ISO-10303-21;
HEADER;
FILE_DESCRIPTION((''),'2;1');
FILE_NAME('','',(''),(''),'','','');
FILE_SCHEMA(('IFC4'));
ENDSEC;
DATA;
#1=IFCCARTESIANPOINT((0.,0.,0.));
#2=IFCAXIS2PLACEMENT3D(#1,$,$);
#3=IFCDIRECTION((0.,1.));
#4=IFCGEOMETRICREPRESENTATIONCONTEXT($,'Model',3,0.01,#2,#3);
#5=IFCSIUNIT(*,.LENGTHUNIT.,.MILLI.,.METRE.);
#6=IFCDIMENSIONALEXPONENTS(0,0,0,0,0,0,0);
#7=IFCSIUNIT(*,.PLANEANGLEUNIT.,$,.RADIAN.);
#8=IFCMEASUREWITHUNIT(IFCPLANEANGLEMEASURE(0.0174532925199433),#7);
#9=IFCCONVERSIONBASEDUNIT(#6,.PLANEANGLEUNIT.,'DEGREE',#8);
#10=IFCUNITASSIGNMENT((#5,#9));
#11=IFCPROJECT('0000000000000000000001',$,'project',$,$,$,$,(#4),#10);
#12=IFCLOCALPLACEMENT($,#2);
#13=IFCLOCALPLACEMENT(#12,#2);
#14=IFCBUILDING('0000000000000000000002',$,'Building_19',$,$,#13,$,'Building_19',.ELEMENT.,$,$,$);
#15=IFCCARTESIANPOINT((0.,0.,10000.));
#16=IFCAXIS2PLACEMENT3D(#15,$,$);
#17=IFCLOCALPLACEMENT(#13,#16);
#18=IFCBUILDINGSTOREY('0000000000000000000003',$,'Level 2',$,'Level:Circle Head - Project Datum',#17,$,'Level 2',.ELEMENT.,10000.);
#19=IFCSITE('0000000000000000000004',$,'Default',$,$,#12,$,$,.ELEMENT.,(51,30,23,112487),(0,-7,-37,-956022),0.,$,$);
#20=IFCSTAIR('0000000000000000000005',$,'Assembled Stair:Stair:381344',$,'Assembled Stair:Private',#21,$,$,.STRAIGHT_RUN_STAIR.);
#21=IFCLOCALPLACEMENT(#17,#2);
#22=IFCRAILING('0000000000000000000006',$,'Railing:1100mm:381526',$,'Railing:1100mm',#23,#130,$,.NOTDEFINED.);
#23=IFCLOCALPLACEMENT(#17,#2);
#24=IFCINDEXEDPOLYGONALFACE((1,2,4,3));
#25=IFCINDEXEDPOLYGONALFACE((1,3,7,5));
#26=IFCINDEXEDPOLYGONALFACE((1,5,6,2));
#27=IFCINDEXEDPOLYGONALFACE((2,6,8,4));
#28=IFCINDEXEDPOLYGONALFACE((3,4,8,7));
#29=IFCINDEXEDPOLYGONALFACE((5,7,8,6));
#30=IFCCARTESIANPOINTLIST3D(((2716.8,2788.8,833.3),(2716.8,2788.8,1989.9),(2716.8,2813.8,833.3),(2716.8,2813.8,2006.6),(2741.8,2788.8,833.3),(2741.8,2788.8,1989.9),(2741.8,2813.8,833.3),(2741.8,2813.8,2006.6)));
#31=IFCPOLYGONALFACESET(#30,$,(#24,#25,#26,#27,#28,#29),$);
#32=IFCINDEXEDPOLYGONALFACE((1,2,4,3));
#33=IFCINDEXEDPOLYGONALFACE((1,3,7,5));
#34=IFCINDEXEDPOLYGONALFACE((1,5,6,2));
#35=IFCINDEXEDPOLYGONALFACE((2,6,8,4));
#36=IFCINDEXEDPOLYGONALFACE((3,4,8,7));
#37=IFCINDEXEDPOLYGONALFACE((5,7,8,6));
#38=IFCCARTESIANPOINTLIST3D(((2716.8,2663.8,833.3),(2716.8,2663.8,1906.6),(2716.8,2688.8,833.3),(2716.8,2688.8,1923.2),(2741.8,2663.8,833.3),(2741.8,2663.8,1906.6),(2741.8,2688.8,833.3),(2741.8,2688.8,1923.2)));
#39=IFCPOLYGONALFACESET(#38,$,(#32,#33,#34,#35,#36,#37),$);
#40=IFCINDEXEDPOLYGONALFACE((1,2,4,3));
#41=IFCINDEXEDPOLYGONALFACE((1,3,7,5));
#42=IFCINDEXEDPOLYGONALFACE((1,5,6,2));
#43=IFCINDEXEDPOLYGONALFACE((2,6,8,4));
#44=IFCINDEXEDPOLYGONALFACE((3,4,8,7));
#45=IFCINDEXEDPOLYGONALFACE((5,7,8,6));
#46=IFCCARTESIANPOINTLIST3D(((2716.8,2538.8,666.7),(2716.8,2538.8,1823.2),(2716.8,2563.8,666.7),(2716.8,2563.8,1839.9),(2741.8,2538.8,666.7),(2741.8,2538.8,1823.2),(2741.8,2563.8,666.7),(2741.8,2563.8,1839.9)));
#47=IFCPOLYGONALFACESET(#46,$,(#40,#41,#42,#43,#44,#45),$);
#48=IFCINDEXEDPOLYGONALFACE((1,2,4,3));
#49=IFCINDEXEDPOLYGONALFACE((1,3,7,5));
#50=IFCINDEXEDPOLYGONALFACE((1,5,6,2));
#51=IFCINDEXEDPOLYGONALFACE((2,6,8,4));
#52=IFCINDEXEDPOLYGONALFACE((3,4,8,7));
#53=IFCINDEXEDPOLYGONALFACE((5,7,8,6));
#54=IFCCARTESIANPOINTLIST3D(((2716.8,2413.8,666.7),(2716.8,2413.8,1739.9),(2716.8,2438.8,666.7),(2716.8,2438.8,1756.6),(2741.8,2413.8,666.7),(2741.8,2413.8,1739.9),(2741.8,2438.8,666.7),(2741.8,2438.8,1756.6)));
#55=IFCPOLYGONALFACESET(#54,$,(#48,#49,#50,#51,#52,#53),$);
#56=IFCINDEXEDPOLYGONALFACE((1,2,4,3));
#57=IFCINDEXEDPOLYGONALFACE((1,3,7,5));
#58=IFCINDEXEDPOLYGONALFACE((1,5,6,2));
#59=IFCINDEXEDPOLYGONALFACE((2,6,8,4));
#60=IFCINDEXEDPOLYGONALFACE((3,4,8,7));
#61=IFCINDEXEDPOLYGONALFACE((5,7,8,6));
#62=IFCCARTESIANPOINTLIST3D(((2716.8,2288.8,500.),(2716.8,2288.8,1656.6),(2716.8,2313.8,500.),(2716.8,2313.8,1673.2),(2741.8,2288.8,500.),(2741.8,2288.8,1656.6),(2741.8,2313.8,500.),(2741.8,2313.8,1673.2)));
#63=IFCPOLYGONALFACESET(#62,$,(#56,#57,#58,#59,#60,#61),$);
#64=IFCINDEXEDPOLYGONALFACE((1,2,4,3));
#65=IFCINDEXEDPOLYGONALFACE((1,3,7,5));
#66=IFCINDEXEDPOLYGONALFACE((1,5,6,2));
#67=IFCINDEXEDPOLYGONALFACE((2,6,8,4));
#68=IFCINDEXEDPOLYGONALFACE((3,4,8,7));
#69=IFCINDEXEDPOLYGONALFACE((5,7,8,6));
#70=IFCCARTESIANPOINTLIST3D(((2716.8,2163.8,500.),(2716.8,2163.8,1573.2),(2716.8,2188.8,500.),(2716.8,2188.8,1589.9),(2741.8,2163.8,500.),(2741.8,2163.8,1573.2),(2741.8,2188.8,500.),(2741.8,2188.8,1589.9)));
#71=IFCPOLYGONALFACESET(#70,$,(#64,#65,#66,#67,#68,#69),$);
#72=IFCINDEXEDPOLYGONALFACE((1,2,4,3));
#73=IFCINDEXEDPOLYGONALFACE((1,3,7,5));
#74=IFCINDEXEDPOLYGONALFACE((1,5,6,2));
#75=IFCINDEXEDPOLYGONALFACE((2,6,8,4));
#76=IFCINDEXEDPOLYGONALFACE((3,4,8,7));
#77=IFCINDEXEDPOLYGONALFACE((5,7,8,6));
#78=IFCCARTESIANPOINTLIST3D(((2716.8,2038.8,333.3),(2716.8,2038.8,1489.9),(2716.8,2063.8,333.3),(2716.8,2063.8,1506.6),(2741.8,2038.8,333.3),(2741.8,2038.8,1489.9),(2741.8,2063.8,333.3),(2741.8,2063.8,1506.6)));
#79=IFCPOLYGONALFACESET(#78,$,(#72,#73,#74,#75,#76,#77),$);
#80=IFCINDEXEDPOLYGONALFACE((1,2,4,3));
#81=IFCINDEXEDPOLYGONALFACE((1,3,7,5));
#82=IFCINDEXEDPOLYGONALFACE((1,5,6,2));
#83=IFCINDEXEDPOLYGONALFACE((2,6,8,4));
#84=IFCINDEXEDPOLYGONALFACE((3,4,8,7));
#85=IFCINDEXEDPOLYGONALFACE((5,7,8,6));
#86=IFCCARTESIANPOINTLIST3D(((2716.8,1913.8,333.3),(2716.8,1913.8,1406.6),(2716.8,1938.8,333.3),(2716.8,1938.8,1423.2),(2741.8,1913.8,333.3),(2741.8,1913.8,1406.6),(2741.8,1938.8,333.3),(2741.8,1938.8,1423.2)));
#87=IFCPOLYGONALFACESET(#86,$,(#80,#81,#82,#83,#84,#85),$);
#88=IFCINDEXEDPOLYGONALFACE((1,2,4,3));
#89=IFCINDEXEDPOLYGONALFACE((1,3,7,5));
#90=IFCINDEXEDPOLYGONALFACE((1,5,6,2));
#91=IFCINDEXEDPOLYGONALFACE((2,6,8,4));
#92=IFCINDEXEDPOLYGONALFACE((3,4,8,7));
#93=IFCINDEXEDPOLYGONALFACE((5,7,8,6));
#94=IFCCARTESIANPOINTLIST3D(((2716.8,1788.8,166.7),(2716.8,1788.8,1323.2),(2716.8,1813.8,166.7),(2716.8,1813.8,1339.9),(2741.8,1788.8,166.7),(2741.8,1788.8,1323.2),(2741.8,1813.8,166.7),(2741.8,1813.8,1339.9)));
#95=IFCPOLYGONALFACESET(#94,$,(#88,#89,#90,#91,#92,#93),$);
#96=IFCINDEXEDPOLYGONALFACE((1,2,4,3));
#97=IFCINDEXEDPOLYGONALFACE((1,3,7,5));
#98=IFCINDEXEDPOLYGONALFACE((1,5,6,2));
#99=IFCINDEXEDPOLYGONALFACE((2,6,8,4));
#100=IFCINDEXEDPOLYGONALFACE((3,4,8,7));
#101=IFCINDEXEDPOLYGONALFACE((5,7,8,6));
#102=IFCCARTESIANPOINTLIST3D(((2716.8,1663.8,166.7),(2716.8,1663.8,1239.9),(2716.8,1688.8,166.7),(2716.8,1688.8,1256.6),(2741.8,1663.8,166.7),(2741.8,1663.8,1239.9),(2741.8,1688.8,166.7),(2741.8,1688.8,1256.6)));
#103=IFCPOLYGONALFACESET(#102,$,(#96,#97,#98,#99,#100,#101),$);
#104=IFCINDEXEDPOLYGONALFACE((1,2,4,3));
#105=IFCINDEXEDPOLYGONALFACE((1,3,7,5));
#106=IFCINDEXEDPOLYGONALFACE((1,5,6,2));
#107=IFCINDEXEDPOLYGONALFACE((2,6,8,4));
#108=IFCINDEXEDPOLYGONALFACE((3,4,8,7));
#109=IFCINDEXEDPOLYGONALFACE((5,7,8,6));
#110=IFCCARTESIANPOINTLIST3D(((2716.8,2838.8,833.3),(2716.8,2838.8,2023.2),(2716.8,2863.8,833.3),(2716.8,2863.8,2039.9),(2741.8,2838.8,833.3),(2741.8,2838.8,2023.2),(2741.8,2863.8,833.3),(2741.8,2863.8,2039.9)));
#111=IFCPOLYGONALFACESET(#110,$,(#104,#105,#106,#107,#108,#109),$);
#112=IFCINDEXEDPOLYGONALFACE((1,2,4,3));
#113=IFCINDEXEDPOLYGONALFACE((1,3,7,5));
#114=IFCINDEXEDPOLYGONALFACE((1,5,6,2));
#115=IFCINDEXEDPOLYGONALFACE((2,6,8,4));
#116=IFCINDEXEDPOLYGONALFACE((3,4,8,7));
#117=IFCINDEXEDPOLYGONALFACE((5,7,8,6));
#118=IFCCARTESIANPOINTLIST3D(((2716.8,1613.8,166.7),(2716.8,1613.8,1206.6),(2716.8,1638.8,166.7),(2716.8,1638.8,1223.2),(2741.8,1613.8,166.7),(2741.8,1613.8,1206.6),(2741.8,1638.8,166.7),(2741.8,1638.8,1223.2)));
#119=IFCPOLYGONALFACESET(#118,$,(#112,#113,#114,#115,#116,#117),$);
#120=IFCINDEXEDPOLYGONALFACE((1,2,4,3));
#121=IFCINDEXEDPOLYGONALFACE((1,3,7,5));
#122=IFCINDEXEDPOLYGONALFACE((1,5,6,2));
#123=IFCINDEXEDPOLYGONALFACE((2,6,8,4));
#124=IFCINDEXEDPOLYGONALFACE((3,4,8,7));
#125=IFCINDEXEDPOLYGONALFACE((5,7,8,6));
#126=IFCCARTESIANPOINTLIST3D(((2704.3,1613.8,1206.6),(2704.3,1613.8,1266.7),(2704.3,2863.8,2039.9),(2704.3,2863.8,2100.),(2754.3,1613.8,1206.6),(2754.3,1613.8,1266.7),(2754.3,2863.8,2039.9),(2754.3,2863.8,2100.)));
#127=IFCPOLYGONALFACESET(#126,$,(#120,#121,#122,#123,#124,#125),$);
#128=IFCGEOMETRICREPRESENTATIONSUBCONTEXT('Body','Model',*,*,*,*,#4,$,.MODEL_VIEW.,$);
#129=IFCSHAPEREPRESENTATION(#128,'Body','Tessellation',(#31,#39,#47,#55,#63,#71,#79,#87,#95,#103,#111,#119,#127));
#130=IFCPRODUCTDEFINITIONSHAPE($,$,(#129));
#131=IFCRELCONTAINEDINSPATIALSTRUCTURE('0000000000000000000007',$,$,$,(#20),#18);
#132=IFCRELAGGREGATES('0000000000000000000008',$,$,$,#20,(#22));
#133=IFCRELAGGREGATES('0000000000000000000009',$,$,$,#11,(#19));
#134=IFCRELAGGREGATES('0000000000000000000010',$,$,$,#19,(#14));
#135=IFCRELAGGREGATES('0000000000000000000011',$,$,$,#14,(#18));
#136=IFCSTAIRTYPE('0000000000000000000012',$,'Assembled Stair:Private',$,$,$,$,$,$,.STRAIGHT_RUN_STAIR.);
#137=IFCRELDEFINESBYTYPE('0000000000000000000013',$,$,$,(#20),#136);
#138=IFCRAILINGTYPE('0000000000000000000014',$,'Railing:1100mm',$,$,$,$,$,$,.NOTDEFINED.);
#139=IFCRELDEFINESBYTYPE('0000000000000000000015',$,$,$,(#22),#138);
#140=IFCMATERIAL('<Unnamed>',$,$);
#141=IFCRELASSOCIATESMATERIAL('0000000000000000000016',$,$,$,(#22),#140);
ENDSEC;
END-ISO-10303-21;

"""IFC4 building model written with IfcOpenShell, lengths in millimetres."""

from ifc_helpers import new_model, entity, si_unit, converted_unit, direction, frame, origin, place, context, subcontext, project, spatial, indexed_curve, outline, extrude, material, type_object, element, aggregate, save


model = new_model("IFC4")

# Units and contexts
model_context = context("Model", 3, precision=0.01, world=origin(), true_north=direction((0.0, 1.0)))
body_context = subcontext(model_context, "Body", "Model", "MODEL_VIEW")
ifc_project = project(units=[si_unit("LENGTHUNIT", "METRE", prefix="MILLI"), converted_unit("PLANEANGLEUNIT", "DEGREE", entity("IfcPlaneAngleMeasure", 0.0174532925199433), si_unit("PLANEANGLEUNIT", "RADIAN"), dimensions=[0, 0, 0, 0, 0, 0, 0])], contexts=[model_context])

# Site, building, storey
site_placement = place(None, origin())
site = spatial("IfcSite", under=ifc_project, at=site_placement, Name="Default", CompositionType="ELEMENT", RefLatitude=(51, 30, 23, 112487), RefLongitude=(0, -7, -37, -956022), RefElevation=0.0)
building_placement = place(site_placement, origin())
building = spatial("IfcBuilding", under=site, at=building_placement, Name="Building_19", LongName="Building_19", CompositionType="ELEMENT")
storey_placement = place(building_placement, frame((0.0, 0.0, 10000.0)))
storey = spatial("IfcBuildingStorey", under=building, at=storey_placement, Name="Level 2", ObjectType="Level:Circle Head - Project Datum", LongName="Level 2", CompositionType="ELEMENT", Elevation=10000.0)

# Stair
stair_type = type_object("IfcStairType", Name="Assembled Stair:Private", PredefinedType="STRAIGHT_RUN_STAIR")
ifc_material_1 = material(Name="<Unnamed>")
stair_1_placement = place(storey_placement, origin())
stair_1 = element("IfcStair", 1, at=stair_1_placement, inside=storey, type_object=stair_type, Name="Assembled Stair:Stair:381344", ObjectType="Assembled Stair:Private", PredefinedType="STRAIGHT_RUN_STAIR")

# Railing
railing_type = type_object("IfcRailingType", Name="Railing:1100mm", PredefinedType="NOTDEFINED")
railing_1_placement = place(stair_1_placement, origin())
railing_1 = element("IfcRailing", 2, at=railing_1_placement, type_object=railing_type, material=ifc_material_1, Name="Railing:1100mm:381526", ObjectType="Railing:1100mm", PredefinedType="NOTDEFINED", context=body_context, shape_type="SweptSolid", body=[
    extrude(outline(indexed_curve([(-574.1, -12.5), (582.5, -12.5), (582.5, 12.5), (-590.8, 12.5), (-574.1, -12.5)], self_intersect=False)), frame((2716.8, 2801.3, 1415.8), z_axis=(1.0, 0.0, 0.0), x_axis=(0.0, 0.0, -1.0)), (0.0, 0.0, 1.0), 25.0),
    extrude(outline(indexed_curve([(-532.5, -12.5), (540.8, -12.5), (540.8, 12.5), (-549.1, 12.5), (-532.5, -12.5)], self_intersect=False)), frame((2716.8, 2676.3, 1374.1), z_axis=(1.0, 0.0, 0.0), x_axis=(0.0, 0.0, -1.0)), (0.0, 0.0, 1.0), 25.0),
    extrude(outline(indexed_curve([(-574.1, -12.5), (582.5, -12.5), (582.5, 12.5), (-590.8, 12.5), (-574.1, -12.5)], self_intersect=False)), frame((2716.8, 2551.3, 1249.1), z_axis=(1.0, 0.0, 0.0), x_axis=(0.0, 0.0, -1.0)), (0.0, 0.0, 1.0), 25.0),
    extrude(outline(indexed_curve([(-532.5, -12.5), (540.8, -12.5), (540.8, 12.5), (-549.1, 12.5), (-532.5, -12.5)], self_intersect=False)), frame((2716.8, 2426.3, 1207.5), z_axis=(1.0, 0.0, 0.0), x_axis=(0.0, 0.0, -1.0)), (0.0, 0.0, 1.0), 25.0),
    extrude(outline(indexed_curve([(-574.1, -12.5), (582.5, -12.5), (582.5, 12.5), (-590.8, 12.5), (-574.1, -12.5)], self_intersect=False)), frame((2716.8, 2301.3, 1082.5), z_axis=(1.0, 0.0, 0.0), x_axis=(0.0, 0.0, -1.0)), (0.0, 0.0, 1.0), 25.0),
    extrude(outline(indexed_curve([(-532.5, -12.5), (540.8, -12.5), (540.8, 12.5), (-549.1, 12.5), (-532.5, -12.5)], self_intersect=False)), frame((2716.8, 2176.3, 1040.8), z_axis=(1.0, 0.0, 0.0), x_axis=(0.0, 0.0, -1.0)), (0.0, 0.0, 1.0), 25.0),
    extrude(outline(indexed_curve([(-574.1, -12.5), (582.5, -12.5), (582.5, 12.5), (-590.8, 12.5), (-574.1, -12.5)], self_intersect=False)), frame((2716.8, 2051.3, 915.8), z_axis=(1.0, 0.0, 0.0), x_axis=(0.0, 0.0, -1.0)), (0.0, 0.0, 1.0), 25.0),
    extrude(outline(indexed_curve([(-532.5, -12.5), (540.8, -12.5), (540.8, 12.5), (-549.1, 12.5), (-532.5, -12.5)], self_intersect=False)), frame((2716.8, 1926.3, 874.1), z_axis=(1.0, 0.0, 0.0), x_axis=(0.0, 0.0, -1.0)), (0.0, 0.0, 1.0), 25.0),
    extrude(outline(indexed_curve([(-574.1, -12.5), (582.5, -12.5), (582.5, 12.5), (-590.8, 12.5), (-574.1, -12.5)], self_intersect=False)), frame((2716.8, 1801.3, 749.1), z_axis=(1.0, 0.0, 0.0), x_axis=(0.0, 0.0, -1.0)), (0.0, 0.0, 1.0), 25.0),
    extrude(outline(indexed_curve([(-532.5, -12.5), (540.8, -12.5), (540.8, 12.5), (-549.1, 12.5), (-532.5, -12.5)], self_intersect=False)), frame((2716.8, 1676.3, 707.5), z_axis=(1.0, 0.0, 0.0), x_axis=(0.0, 0.0, -1.0)), (0.0, 0.0, 1.0), 25.0),
    extrude(outline(indexed_curve([(-590.8, -12.5), (599.1, -12.5), (599.1, 12.5), (-607.5, 12.5), (-590.8, -12.5)], self_intersect=False)), frame((2716.8, 2851.3, 1432.5), z_axis=(1.0, 0.0, 0.0), x_axis=(0.0, 0.0, -1.0)), (0.0, 0.0, 1.0), 25.0),
    extrude(outline(indexed_curve([(-515.8, -12.5), (524.1, -12.5), (524.1, 12.5), (-532.5, 12.5), (-515.8, -12.5)], self_intersect=False)), frame((2716.8, 1626.3, 690.8), z_axis=(1.0, 0.0, 0.0), x_axis=(0.0, 0.0, -1.0)), (0.0, 0.0, 1.0), 25.0),
    extrude(outline(indexed_curve([(-767.8, -25.0), (734.5, -25.0), (767.8, 25.0), (-734.5, 25.0), (-767.8, -25.0)], self_intersect=False)), frame((2704.3, 2238.8, 1653.3), z_axis=(1.0, 0.0, 0.0), x_axis=(0.0, 0.83205, 0.5547)), (0.0, 0.0, 1.0), 50.0),
])
aggregate(stair_1, [railing_1])

save(model, "model.ifc")
